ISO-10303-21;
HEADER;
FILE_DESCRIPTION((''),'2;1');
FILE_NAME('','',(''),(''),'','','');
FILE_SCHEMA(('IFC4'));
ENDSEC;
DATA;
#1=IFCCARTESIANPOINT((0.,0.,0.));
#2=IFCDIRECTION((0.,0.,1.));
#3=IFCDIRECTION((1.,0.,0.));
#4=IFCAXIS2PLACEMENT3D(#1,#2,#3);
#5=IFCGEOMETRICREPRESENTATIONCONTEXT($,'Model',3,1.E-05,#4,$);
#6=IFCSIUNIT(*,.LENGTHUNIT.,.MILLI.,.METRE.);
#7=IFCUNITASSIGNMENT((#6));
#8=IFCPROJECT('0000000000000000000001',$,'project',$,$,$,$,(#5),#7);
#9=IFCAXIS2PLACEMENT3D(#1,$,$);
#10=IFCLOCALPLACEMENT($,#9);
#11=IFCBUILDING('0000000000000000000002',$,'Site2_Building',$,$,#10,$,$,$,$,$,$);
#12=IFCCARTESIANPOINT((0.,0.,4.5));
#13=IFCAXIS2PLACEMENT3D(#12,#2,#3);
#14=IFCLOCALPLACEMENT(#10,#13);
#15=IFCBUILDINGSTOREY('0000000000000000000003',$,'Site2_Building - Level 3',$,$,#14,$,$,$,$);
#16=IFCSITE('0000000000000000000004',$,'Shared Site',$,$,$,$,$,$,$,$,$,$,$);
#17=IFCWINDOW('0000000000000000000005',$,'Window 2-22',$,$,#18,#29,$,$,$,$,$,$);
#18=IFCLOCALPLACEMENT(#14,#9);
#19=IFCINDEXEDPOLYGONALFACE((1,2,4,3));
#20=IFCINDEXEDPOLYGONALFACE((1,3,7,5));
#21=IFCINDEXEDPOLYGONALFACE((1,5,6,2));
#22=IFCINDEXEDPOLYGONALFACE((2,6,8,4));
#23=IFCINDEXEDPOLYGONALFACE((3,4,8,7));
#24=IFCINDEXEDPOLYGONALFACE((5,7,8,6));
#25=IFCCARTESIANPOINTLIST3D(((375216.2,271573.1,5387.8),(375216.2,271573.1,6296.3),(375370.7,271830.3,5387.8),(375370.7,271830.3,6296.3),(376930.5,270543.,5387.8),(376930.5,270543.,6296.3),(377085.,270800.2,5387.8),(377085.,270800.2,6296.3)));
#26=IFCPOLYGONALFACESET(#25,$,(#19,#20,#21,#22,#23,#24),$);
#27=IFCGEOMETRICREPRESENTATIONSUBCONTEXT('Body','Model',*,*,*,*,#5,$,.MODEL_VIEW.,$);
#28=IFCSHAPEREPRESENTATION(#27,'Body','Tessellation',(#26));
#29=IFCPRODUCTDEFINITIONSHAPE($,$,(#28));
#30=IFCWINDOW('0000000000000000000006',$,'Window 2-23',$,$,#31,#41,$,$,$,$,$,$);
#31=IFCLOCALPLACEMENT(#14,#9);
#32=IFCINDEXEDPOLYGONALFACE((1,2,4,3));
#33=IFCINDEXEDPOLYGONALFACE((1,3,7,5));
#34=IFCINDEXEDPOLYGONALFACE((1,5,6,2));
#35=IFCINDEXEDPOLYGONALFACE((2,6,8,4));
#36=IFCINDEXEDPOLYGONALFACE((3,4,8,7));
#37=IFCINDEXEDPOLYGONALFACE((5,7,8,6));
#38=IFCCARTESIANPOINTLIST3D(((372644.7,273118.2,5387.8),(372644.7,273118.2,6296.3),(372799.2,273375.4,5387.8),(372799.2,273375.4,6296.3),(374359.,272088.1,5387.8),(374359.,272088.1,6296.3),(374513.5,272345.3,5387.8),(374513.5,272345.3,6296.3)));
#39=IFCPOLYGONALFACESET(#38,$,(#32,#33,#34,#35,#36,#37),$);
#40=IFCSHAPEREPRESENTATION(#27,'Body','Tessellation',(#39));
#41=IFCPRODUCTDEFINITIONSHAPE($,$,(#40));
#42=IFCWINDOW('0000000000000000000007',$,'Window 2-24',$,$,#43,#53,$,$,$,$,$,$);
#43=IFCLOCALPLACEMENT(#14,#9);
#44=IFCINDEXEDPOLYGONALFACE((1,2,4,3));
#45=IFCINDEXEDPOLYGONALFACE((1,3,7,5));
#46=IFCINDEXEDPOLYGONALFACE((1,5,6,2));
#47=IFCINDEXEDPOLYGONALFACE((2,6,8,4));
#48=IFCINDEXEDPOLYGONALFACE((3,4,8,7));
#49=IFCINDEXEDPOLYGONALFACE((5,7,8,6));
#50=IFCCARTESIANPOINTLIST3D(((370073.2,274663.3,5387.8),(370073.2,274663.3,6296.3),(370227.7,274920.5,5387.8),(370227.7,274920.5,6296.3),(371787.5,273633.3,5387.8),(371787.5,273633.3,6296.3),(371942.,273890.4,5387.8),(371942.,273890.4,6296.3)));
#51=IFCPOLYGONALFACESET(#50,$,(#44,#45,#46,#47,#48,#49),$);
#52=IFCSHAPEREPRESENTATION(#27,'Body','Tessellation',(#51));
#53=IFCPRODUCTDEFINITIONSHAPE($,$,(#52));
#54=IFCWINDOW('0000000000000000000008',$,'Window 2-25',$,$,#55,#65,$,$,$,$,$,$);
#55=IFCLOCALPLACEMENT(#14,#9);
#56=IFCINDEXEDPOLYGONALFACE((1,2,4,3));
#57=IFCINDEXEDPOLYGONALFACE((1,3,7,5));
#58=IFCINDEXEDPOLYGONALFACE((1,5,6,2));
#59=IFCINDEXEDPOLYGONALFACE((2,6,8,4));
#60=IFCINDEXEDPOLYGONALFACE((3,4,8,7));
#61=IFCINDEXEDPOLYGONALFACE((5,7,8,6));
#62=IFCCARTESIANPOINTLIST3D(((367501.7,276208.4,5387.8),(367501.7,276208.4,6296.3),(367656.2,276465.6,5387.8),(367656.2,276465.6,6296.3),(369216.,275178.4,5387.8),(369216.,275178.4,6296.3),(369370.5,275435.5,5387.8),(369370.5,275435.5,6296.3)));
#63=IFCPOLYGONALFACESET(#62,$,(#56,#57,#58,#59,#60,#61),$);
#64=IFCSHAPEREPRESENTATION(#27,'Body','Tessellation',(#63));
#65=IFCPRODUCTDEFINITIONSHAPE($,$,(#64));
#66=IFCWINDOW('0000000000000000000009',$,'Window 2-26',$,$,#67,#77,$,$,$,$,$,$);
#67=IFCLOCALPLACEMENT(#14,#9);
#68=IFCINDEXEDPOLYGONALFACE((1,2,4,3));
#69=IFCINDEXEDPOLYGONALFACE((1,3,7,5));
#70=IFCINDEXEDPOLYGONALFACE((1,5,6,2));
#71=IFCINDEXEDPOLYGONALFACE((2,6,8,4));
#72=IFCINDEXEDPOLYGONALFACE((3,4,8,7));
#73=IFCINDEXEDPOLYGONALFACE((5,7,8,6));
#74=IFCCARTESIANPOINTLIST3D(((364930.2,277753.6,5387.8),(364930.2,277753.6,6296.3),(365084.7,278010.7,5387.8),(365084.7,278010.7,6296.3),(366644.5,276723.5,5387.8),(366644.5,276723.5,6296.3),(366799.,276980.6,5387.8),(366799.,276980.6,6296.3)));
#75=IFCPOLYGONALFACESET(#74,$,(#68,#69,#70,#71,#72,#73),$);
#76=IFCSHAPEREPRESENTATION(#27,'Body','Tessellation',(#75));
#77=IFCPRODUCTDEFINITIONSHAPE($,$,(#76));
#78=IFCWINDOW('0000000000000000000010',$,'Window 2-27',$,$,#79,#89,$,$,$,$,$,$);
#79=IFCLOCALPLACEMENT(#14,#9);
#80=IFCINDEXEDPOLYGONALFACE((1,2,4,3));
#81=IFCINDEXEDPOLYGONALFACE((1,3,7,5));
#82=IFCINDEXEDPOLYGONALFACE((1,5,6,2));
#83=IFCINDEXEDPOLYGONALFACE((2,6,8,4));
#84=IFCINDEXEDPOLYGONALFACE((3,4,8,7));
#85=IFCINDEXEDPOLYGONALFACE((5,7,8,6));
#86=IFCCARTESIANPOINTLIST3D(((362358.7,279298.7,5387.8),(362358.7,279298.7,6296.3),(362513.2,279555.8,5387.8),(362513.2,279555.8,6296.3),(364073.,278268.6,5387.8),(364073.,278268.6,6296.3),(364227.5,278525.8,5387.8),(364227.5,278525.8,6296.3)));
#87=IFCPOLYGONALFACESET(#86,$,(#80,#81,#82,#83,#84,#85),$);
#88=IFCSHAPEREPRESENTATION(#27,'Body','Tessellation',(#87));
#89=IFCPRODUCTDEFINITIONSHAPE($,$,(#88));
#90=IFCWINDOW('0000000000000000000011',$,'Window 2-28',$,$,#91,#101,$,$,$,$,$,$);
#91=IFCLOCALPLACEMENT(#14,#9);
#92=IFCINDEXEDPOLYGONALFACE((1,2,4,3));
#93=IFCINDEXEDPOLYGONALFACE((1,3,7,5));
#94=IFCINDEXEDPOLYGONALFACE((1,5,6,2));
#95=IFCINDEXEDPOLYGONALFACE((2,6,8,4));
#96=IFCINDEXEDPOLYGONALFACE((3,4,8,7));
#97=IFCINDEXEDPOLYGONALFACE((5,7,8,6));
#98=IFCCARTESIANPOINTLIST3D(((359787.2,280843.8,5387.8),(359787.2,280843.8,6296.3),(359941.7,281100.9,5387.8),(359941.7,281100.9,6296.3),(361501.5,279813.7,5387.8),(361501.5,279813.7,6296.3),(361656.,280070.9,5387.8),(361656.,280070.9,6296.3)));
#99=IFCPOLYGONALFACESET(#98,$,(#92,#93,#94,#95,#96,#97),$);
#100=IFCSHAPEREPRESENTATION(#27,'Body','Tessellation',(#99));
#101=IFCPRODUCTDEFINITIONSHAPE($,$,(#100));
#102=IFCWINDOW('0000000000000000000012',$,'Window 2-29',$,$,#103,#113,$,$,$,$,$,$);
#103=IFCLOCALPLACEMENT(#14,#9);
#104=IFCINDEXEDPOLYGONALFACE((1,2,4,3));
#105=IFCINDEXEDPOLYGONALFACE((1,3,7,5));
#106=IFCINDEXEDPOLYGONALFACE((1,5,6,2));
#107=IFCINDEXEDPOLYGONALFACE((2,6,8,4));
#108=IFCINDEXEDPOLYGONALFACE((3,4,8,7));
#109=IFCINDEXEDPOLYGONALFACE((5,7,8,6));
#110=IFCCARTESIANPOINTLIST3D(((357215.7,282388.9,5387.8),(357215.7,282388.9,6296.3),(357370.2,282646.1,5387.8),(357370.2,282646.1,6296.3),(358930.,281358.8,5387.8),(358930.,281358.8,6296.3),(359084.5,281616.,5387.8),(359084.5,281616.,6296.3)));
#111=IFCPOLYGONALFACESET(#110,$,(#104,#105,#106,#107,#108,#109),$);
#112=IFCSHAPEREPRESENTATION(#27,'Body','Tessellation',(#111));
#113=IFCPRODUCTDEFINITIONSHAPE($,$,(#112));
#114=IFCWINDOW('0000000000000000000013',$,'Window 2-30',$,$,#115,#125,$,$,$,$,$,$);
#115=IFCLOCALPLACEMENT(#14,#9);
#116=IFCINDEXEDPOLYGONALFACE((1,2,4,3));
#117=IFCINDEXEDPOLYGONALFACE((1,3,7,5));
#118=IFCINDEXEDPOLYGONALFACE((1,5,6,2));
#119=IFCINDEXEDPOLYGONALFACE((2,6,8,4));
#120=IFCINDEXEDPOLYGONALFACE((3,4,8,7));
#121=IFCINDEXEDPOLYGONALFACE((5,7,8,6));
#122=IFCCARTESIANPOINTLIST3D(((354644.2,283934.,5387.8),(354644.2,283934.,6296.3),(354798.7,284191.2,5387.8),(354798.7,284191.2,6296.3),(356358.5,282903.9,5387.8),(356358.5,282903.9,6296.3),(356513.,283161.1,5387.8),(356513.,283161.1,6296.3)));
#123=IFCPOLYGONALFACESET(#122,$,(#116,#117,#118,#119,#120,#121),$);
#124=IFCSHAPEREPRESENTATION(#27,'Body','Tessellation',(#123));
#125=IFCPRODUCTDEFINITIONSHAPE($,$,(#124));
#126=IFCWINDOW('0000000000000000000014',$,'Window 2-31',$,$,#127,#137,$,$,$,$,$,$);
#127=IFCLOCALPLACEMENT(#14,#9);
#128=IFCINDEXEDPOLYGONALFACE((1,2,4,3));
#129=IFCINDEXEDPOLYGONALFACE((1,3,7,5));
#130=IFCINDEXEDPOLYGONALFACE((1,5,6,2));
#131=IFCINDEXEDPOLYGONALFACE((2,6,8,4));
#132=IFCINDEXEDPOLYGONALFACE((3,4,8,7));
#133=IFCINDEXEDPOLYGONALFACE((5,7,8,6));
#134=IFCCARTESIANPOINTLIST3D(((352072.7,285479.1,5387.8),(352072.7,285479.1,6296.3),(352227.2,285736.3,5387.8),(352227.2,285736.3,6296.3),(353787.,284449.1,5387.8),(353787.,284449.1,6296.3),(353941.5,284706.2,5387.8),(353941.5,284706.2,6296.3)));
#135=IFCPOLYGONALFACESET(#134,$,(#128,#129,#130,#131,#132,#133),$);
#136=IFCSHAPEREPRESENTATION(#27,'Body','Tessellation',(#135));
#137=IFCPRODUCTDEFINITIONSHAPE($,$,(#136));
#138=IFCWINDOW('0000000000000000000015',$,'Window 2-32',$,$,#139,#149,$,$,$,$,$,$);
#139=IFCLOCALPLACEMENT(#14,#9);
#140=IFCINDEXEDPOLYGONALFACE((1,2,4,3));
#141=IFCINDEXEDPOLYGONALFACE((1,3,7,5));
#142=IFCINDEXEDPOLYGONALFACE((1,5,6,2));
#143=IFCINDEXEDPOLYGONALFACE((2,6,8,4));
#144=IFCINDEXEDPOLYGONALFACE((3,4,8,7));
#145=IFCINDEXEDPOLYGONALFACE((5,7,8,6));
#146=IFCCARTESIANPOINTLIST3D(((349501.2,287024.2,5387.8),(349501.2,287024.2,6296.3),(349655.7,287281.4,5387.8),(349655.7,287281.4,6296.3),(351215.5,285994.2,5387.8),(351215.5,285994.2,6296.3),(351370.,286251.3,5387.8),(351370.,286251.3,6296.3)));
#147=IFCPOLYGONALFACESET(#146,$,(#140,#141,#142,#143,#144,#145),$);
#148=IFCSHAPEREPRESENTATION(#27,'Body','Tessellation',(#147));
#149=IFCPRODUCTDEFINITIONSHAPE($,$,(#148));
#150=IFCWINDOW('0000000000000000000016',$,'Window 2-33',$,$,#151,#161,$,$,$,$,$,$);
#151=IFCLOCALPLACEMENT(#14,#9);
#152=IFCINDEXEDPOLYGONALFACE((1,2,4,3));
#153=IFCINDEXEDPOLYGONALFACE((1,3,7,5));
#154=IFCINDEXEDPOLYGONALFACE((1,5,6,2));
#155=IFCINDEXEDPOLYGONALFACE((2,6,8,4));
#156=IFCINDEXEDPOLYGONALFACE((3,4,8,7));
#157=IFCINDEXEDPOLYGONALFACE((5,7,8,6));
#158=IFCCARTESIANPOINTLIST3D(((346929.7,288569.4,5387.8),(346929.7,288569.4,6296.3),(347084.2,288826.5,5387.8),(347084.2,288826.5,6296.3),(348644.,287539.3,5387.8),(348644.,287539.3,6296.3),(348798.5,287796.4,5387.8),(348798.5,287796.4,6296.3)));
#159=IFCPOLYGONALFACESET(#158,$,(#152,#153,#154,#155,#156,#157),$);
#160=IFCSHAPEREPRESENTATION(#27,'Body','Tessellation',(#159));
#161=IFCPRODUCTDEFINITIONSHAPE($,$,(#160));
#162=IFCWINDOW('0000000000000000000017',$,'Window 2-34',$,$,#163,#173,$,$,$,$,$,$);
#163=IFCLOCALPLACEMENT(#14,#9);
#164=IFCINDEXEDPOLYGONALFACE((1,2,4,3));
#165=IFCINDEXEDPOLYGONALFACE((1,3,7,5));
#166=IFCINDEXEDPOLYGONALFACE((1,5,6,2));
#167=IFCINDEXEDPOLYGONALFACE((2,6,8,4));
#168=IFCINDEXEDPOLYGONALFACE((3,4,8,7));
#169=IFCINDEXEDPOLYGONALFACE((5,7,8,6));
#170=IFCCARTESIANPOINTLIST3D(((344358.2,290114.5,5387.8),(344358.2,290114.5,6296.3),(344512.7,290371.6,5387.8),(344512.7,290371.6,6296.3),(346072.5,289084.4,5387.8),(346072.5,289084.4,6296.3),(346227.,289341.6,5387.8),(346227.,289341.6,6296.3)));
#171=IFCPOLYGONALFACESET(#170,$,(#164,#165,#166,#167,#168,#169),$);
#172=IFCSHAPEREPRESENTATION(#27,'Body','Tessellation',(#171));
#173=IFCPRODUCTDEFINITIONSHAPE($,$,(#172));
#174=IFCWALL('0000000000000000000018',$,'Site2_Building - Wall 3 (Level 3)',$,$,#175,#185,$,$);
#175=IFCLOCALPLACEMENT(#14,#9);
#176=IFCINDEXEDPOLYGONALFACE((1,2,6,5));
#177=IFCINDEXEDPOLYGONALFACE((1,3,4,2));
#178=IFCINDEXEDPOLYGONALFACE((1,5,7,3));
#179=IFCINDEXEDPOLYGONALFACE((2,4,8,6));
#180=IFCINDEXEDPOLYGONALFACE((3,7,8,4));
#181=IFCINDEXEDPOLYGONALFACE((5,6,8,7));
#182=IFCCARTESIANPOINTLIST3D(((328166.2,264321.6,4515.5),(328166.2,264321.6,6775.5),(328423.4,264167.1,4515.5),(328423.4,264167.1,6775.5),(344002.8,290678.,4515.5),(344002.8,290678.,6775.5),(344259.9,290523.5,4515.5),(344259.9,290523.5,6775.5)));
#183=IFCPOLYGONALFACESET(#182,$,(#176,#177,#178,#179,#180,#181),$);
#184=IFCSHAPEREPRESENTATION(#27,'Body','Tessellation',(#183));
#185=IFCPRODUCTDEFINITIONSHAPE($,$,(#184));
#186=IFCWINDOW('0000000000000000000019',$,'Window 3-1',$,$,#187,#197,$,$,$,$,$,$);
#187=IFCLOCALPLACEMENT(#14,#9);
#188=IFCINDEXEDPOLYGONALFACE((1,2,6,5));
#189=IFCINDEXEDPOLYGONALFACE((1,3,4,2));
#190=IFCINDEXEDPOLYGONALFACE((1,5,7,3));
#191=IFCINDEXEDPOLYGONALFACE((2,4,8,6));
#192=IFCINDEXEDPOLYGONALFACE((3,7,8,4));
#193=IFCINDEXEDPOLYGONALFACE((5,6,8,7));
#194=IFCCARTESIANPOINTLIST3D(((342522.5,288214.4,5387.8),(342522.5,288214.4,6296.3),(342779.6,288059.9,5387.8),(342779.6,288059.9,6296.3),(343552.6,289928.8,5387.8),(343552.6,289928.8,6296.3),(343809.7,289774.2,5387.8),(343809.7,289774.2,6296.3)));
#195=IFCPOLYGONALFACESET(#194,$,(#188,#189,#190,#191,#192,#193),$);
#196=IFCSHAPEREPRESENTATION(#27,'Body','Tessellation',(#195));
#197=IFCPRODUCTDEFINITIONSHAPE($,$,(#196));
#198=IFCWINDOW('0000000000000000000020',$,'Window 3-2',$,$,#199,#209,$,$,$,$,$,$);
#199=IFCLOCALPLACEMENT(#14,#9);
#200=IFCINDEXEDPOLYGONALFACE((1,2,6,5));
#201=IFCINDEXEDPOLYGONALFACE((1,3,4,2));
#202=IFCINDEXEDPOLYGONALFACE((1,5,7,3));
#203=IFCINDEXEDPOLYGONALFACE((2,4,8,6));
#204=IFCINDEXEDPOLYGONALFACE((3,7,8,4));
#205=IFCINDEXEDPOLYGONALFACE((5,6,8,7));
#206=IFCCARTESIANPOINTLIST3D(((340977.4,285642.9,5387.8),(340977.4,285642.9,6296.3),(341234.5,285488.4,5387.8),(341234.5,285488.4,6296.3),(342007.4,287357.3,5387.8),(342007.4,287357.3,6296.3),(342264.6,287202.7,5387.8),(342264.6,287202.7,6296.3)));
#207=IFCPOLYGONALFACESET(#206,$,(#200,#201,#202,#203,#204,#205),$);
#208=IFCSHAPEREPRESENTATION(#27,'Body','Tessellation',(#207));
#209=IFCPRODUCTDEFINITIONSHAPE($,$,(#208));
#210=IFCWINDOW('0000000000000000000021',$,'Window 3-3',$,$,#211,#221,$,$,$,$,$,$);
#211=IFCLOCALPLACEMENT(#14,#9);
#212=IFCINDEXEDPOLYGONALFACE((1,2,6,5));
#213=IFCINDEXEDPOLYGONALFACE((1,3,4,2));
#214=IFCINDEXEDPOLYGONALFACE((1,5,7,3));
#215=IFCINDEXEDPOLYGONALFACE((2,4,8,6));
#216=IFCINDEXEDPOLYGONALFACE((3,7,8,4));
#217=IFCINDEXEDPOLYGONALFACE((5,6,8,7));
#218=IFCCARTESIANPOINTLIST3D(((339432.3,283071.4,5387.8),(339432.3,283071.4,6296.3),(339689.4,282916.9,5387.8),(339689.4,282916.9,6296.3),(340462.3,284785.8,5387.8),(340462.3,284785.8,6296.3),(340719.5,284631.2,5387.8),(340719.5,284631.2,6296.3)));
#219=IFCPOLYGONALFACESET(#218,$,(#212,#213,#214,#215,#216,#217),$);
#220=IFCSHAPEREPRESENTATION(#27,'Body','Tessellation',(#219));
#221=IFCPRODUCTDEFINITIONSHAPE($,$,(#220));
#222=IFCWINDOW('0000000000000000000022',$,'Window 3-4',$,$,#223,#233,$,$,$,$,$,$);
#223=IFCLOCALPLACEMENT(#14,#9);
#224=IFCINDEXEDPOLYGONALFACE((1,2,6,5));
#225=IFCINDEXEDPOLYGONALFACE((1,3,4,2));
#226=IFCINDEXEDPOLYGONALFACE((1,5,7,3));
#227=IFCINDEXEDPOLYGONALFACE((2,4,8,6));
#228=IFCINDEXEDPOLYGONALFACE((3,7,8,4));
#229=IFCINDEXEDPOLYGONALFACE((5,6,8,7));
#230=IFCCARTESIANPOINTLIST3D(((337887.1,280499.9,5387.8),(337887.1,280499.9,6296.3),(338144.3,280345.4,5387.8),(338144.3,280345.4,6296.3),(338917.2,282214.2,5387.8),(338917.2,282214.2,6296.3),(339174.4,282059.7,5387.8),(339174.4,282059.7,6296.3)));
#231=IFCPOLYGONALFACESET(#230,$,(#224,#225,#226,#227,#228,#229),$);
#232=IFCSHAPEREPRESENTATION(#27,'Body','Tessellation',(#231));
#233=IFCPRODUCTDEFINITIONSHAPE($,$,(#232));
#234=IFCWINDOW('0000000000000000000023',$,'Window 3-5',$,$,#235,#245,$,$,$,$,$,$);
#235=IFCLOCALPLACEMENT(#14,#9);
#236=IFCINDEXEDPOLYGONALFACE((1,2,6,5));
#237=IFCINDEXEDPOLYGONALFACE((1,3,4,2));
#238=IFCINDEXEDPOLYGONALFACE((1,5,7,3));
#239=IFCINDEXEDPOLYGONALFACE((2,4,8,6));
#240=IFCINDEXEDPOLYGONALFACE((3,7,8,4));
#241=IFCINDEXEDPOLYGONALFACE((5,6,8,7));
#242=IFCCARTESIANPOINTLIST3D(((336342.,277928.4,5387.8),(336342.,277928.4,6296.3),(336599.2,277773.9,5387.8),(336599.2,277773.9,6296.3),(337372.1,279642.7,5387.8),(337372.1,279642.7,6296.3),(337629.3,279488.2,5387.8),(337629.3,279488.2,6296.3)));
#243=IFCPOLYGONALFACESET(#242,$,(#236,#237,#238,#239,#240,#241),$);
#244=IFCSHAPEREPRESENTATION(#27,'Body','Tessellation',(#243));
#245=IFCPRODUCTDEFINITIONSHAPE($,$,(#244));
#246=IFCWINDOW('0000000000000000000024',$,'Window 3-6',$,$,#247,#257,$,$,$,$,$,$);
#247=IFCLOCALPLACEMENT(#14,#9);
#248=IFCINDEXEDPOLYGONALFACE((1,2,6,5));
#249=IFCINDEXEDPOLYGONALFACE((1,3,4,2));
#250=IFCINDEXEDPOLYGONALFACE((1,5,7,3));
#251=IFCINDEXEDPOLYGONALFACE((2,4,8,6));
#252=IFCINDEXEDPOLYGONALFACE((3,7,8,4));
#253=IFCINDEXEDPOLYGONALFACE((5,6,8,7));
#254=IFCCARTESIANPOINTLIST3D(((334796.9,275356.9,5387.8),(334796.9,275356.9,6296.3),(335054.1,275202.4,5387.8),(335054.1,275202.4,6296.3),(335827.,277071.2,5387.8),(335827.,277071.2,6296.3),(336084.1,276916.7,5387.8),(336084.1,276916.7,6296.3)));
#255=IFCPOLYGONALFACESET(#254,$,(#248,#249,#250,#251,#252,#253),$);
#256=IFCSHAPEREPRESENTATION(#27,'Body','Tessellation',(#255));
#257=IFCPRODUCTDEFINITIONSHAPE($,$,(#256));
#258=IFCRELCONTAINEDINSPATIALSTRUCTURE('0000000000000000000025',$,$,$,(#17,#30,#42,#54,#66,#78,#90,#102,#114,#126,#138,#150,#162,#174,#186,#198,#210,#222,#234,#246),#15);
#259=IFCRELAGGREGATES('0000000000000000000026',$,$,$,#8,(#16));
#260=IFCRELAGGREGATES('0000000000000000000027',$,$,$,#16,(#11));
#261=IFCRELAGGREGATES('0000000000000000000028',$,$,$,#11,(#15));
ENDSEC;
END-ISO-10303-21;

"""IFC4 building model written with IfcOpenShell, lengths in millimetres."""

from ifc_helpers import new_model, si_unit, frame, origin, origin_with_axes, place, context, subcontext, project, spatial, indexed_curve, outline, extrude, element, save


model = new_model("IFC4")

# Units and contexts
model_context = context("Model", 3, precision=1e-05, world=origin_with_axes())
body_context = subcontext(model_context, "Body", "Model", "MODEL_VIEW")
ifc_project = project(units=[si_unit("LENGTHUNIT", "METRE", prefix="MILLI")], contexts=[model_context])

# Site, building, storey
site = spatial("IfcSite", under=ifc_project, Name="Shared Site")
building_placement = place(None, origin())
building = spatial("IfcBuilding", under=site, at=building_placement, Name="Site2_Building")
storey_placement = place(building_placement, frame((0.0, 0.0, 4.5), z_axis=(0.0, 0.0, 1.0), x_axis=(1.0, 0.0, 0.0)))
storey = spatial("IfcBuildingStorey", under=building, at=storey_placement, Name="Site2_Building - Level 3")

# Windows
for number, where, z_axis, x_axis, name in (
    (1, (377085.0, 270800.2, 5387.8), (0.0, 0.0, 1.0), (-0.857167, 0.515038, 0.0), "Window 2-22"),
    (2, (374513.5, 272345.3, 5387.8), (0.0, 0.0, 1.0), (-0.857167, 0.515038, 0.0), "Window 2-23"),
    (3, (371942.0, 273890.4, 5387.8), (0.0, 0.0, 1.0), (-0.857167, 0.515038, 0.0), "Window 2-24"),
    (4, (369370.5, 275435.5, 5387.8), (0.0, 0.0, 1.0), (-0.857167, 0.515038, 0.0), "Window 2-25"),
    (5, (366799.0, 276980.6, 5387.8), (0.0, 0.0, 1.0), (-0.857167, 0.515038, 0.0), "Window 2-26"),
    (6, (364227.5, 278525.8, 5387.8), (0.0, 0.0, 1.0), (-0.857167, 0.515038, 0.0), "Window 2-27"),
    (7, (361656.0, 280070.9, 5387.8), (0.0, 0.0, 1.0), (-0.857167, 0.515038, 0.0), "Window 2-28"),
    (8, (359084.5, 281616.0, 5387.8), (0.0, 0.0, 1.0), (-0.857167, 0.515038, 0.0), "Window 2-29"),
    (9, (356513.0, 283161.1, 5387.8), (0.0, 0.0, 1.0), (-0.857167, 0.515038, 0.0), "Window 2-30"),
    (10, (353941.5, 284706.2, 5387.8), (0.0, 0.0, 1.0), (-0.857167, 0.515038, 0.0), "Window 2-31"),
    (11, (351370.0, 286251.3, 5387.8), (0.0, 0.0, 1.0), (-0.857167, 0.515038, 0.0), "Window 2-32"),
    (12, (348798.5, 287796.4, 5387.8), (0.0, 0.0, 1.0), (-0.857167, 0.515038, 0.0), "Window 2-33"),
    (13, (346227.0, 289341.6, 5387.8), (0.0, 0.0, 1.0), (-0.857167, 0.515038, 0.0), "Window 2-34"),
):
    element("IfcWindow", number, at=place(storey_placement, frame(where, z_axis=z_axis, x_axis=x_axis)), inside=storey, Name=name, context=body_context, shape_type="SweptSolid", body=[
        extrude(outline(indexed_curve([(0.0, 0.0), (0.0, 300.0), (2000.0, 300.0), (2000.0, 0.0), (0.0, 0.0)], self_intersect=False)), origin_with_axes(), (0.0, 0.0, 1.0), 908.6),
    ])

# Wall
wall_placement = place(storey_placement, frame((344002.8, 290678.0, 4515.5), z_axis=(0.0, 0.0, 1.0), x_axis=(-0.515038, -0.857167, 0.0)))
element("IfcWall", 14, at=wall_placement, inside=storey, Name="Site2_Building - Wall 3 (Level 3)", context=body_context, shape_type="SweptSolid", body=[
    extrude(outline(indexed_curve([(0.0, 0.0), (0.0, 300.0), (30748.2, 300.0), (30748.2, 0.0), (0.0, 0.0)], self_intersect=False)), origin_with_axes(), (0.0, 0.0, 1.0), 2260.0),
])

# Windows
for number, where, z_axis, x_axis, name in (
    (15, (343552.6, 289928.8, 5387.8), (0.0, 0.0, 1.0), (-0.515038, -0.857167, 0.0), "Window 3-1"),
    (16, (342007.4, 287357.3, 5387.8), (0.0, 0.0, 1.0), (-0.515038, -0.857167, 0.0), "Window 3-2"),
    (17, (340462.3, 284785.8, 5387.8), (0.0, 0.0, 1.0), (-0.515038, -0.857167, 0.0), "Window 3-3"),
    (18, (338917.2, 282214.2, 5387.8), (0.0, 0.0, 1.0), (-0.515038, -0.857167, 0.0), "Window 3-4"),
    (19, (337372.1, 279642.7, 5387.8), (0.0, 0.0, 1.0), (-0.515038, -0.857167, 0.0), "Window 3-5"),
    (20, (335827.0, 277071.2, 5387.8), (0.0, 0.0, 1.0), (-0.515038, -0.857167, 0.0), "Window 3-6"),
):
    element("IfcWindow", number, at=place(storey_placement, frame(where, z_axis=z_axis, x_axis=x_axis)), inside=storey, Name=name, context=body_context, shape_type="SweptSolid", body=[
        extrude(outline(indexed_curve([(0.0, 0.0), (0.0, 300.0), (2000.0, 300.0), (2000.0, 0.0), (0.0, 0.0)], self_intersect=False)), origin_with_axes(), (0.0, 0.0, 1.0), 908.6),
    ])

save(model, "model.ifc")
